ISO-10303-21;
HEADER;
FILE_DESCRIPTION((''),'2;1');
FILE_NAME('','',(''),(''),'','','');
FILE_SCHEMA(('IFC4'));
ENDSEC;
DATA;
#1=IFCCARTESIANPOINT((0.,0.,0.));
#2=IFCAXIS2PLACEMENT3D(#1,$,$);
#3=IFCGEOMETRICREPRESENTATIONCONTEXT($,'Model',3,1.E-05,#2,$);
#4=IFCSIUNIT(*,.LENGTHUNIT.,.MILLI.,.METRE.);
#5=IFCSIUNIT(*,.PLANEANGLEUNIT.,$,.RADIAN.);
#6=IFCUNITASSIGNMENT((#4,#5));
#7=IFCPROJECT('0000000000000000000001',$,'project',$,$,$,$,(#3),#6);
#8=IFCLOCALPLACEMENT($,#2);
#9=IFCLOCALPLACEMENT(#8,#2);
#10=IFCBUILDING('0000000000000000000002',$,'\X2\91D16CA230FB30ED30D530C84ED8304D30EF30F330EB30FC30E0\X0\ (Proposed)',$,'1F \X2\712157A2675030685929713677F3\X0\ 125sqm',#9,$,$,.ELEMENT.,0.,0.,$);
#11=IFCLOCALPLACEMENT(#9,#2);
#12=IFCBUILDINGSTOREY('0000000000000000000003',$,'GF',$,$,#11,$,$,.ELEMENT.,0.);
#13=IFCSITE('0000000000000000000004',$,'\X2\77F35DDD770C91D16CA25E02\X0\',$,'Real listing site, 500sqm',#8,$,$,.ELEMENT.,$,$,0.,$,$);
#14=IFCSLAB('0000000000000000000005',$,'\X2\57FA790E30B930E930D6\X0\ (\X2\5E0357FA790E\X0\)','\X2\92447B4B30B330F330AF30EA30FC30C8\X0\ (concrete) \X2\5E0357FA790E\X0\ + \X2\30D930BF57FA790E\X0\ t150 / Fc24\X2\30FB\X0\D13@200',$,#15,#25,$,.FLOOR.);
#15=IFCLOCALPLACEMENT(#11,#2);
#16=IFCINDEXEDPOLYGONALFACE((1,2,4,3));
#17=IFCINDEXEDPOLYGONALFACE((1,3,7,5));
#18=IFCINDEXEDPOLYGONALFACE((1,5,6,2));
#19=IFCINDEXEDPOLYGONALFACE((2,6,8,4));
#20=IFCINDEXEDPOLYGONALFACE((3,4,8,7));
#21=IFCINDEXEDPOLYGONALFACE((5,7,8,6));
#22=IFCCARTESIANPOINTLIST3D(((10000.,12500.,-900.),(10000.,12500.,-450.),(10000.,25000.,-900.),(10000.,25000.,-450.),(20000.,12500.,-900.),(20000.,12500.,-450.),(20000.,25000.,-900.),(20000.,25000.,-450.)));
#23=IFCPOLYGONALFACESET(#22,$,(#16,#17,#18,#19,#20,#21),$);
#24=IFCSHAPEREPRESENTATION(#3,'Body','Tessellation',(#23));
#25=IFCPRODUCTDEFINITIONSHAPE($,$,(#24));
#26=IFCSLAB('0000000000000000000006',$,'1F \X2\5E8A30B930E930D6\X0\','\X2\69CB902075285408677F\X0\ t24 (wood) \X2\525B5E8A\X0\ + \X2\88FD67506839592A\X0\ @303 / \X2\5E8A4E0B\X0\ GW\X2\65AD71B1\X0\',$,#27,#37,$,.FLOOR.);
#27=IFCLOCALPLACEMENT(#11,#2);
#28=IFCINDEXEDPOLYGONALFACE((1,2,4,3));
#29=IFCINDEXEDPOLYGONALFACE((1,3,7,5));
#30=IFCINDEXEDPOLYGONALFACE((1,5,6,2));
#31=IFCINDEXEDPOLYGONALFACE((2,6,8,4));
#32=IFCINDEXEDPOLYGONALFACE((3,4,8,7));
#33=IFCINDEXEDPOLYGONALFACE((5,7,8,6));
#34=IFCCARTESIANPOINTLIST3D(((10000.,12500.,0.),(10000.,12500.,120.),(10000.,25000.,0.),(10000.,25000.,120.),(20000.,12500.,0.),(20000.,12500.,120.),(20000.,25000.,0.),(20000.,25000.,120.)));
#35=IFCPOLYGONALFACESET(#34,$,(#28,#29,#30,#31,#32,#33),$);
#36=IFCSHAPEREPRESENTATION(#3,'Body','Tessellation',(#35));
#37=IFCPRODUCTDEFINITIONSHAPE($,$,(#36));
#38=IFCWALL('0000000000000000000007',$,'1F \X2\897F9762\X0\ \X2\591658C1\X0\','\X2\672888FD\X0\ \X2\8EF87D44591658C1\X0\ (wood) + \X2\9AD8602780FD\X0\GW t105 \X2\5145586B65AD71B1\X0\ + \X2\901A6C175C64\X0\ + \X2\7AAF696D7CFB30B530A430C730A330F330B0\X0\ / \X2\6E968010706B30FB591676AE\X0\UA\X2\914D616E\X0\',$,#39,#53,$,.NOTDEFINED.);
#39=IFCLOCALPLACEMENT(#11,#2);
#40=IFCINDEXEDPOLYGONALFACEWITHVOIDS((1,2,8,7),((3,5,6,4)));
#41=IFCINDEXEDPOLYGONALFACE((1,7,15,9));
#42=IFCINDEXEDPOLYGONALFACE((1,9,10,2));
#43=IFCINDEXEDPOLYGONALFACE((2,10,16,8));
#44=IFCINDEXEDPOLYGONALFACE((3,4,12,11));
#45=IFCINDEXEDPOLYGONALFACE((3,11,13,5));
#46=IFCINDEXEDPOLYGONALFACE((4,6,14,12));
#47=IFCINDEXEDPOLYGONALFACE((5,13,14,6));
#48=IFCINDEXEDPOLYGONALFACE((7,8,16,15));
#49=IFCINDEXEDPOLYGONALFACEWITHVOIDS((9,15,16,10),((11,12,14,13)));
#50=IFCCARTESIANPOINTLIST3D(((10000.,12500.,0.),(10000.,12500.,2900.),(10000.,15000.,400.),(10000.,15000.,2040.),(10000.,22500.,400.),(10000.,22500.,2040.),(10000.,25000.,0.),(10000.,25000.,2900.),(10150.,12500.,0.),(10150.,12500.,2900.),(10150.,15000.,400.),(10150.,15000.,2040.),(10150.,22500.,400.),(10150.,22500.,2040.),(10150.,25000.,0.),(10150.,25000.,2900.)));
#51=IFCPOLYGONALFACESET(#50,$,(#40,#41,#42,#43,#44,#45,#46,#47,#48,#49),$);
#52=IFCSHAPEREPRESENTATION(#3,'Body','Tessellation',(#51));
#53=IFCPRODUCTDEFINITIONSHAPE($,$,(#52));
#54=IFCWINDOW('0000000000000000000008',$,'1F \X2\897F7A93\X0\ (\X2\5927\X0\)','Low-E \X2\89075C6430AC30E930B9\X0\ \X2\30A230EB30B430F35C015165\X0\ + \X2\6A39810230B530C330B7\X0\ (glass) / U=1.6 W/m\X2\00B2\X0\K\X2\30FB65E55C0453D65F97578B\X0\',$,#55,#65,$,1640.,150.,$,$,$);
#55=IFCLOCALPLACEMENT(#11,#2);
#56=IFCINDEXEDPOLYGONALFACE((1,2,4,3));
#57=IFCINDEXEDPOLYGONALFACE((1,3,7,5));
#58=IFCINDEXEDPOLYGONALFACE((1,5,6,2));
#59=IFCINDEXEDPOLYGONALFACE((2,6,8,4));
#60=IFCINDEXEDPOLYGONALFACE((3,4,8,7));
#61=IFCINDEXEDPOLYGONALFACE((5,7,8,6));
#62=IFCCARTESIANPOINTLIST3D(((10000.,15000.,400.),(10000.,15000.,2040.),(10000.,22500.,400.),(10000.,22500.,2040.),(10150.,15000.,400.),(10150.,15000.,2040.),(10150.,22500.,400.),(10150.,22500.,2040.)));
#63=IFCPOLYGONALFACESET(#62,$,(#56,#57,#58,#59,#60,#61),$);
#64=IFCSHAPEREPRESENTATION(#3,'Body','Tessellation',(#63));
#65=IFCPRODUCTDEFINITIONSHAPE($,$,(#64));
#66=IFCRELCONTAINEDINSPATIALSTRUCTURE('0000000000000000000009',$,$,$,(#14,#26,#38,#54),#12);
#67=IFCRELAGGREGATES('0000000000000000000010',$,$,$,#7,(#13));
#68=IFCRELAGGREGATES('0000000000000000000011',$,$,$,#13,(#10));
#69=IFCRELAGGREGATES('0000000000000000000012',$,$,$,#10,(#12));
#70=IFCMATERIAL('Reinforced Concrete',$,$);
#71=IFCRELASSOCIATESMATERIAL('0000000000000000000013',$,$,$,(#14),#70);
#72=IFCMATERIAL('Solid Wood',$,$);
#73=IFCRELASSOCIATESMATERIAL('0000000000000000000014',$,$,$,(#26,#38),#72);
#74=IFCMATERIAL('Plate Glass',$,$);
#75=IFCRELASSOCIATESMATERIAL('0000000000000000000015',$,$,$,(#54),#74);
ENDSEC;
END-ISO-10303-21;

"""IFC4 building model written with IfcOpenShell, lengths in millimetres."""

from ifc_helpers import new_model, si_unit, frame, frame_2d, origin, place, context, project, spatial, rectangle, extrude, material, element, fill, save


model = new_model("IFC4")

# Units and contexts
model_context = context("Model", 3, precision=1e-05, world=origin())
ifc_project = project(units=[si_unit("LENGTHUNIT", "METRE", prefix="MILLI"), si_unit("PLANEANGLEUNIT", "RADIAN")], contexts=[model_context])

# Site, building, storey
site_placement = place(None, origin())
site = spatial("IfcSite", under=ifc_project, at=site_placement, Name="石川県金沢市", ObjectType="Real listing site, 500sqm", CompositionType="ELEMENT", RefElevation=0.0)
building_placement = place(site_placement, origin())
building = spatial("IfcBuilding", under=site, at=building_placement, Name="金沢・ロフト付きワンルーム (Proposed)", ObjectType="1F 無垢材と天然石 125sqm", CompositionType="ELEMENT", ElevationOfRefHeight=0.0, ElevationOfTerrain=0.0)
storey_placement = place(building_placement, origin())
storey = spatial("IfcBuildingStorey", under=building, at=storey_placement, Name="GF", CompositionType="ELEMENT", Elevation=0.0)

# Shared definitions
ifc_material_1 = material(Name="Solid Wood")

# Slabs
ifc_material_2 = material(Name="Reinforced Concrete")
slab_1_placement = place(storey_placement, frame((5000.0, 6250.0, -450.0)))
element("IfcSlab", 1, at=slab_1_placement, inside=storey, material=ifc_material_2, Name="基礎スラブ (布基礎)", Description="鉄筋コンクリート (concrete) 布基礎 + ベタ基礎 t150 / Fc24・D13@200", PredefinedType="FLOOR", context=model_context, shape_type="SweptSolid", body=[
    extrude(rectangle(XDim=10000.0, YDim=12500.0, at=frame_2d((5000.0, 6250.0))), frame((5000.0, 6250.0, -450.0)), (0.0, 0.0, 1.0), 450.0),
])
slab_2_placement = place(storey_placement, frame((5000.0, 6250.0, 0.0)))
element("IfcSlab", 2, at=slab_2_placement, inside=storey, material=ifc_material_1, Name="1F 床スラブ", Description="構造用合板 t24 (wood) 剛床 + 製材根太 @303 / 床下 GW断熱", PredefinedType="FLOOR", context=model_context, shape_type="SweptSolid", body=[
    extrude(rectangle(XDim=10000.0, YDim=12500.0, at=frame_2d((5000.0, 6250.0))), frame((5000.0, 6250.0, 0.0)), (0.0, 0.0, 1.0), 120.0),
])

# Shared definitions
ifc_material_3 = material(Name="Plate Glass")

# Wall, opening, window
wall_1_placement = place(storey_placement, frame((5000.0, 6250.0, 0.0)))
wall_1 = element("IfcWall", 3, at=wall_1_placement, inside=storey, material=ifc_material_1, Name="1F 西面 外壁", Description="木製 軸組外壁 (wood) + 高性能GW t105 充填断熱 + 通気層 + 窯業系サイディング / 準耐火・外皮UA配慮", PredefinedType="NOTDEFINED", context=model_context, shape_type="SweptSolid", body=[
    extrude(rectangle(XDim=150.0, YDim=12500.0, at=frame_2d((75.0, 6250.0))), frame((5000.0, 6250.0, 0.0)), (0.0, 0.0, 1.0), 2900.0),
])
opening_1_placement = place(storey_placement, frame((5000.0, 7500.0, 200.0)))
opening_1 = element("IfcOpeningElement", 4, at=opening_1_placement, cuts=wall_1, PredefinedType="NOTDEFINED", context=model_context, shape_type="SweptSolid", body=[
    extrude(rectangle(XDim=150.0, YDim=7500.0, at=frame_2d((75.0, 3750.0))), frame((5000.0, 7500.0, 200.0)), (0.0, 0.0, 1.0), 1640.0),
])
window_1_placement = place(storey_placement, frame((5000.0, 7500.0, 200.0)))
window_1 = element("IfcWindow", 5, at=window_1_placement, inside=storey, material=ifc_material_3, Name="1F 西窓 (大)", Description="Low-E 複層ガラス アルゴン封入 + 樹脂サッシ (glass) / U=1.6 W/m²K・日射取得型", OverallHeight=1640.0, OverallWidth=150.0, context=model_context, shape_type="SweptSolid", body=[
    extrude(rectangle(XDim=150.0, YDim=7500.0, at=frame_2d((75.0, 3750.0))), frame((5000.0, 7500.0, 200.0)), (0.0, 0.0, 1.0), 1640.0),
])
fill(opening_1, window_1)

save(model, "model.ifc")
